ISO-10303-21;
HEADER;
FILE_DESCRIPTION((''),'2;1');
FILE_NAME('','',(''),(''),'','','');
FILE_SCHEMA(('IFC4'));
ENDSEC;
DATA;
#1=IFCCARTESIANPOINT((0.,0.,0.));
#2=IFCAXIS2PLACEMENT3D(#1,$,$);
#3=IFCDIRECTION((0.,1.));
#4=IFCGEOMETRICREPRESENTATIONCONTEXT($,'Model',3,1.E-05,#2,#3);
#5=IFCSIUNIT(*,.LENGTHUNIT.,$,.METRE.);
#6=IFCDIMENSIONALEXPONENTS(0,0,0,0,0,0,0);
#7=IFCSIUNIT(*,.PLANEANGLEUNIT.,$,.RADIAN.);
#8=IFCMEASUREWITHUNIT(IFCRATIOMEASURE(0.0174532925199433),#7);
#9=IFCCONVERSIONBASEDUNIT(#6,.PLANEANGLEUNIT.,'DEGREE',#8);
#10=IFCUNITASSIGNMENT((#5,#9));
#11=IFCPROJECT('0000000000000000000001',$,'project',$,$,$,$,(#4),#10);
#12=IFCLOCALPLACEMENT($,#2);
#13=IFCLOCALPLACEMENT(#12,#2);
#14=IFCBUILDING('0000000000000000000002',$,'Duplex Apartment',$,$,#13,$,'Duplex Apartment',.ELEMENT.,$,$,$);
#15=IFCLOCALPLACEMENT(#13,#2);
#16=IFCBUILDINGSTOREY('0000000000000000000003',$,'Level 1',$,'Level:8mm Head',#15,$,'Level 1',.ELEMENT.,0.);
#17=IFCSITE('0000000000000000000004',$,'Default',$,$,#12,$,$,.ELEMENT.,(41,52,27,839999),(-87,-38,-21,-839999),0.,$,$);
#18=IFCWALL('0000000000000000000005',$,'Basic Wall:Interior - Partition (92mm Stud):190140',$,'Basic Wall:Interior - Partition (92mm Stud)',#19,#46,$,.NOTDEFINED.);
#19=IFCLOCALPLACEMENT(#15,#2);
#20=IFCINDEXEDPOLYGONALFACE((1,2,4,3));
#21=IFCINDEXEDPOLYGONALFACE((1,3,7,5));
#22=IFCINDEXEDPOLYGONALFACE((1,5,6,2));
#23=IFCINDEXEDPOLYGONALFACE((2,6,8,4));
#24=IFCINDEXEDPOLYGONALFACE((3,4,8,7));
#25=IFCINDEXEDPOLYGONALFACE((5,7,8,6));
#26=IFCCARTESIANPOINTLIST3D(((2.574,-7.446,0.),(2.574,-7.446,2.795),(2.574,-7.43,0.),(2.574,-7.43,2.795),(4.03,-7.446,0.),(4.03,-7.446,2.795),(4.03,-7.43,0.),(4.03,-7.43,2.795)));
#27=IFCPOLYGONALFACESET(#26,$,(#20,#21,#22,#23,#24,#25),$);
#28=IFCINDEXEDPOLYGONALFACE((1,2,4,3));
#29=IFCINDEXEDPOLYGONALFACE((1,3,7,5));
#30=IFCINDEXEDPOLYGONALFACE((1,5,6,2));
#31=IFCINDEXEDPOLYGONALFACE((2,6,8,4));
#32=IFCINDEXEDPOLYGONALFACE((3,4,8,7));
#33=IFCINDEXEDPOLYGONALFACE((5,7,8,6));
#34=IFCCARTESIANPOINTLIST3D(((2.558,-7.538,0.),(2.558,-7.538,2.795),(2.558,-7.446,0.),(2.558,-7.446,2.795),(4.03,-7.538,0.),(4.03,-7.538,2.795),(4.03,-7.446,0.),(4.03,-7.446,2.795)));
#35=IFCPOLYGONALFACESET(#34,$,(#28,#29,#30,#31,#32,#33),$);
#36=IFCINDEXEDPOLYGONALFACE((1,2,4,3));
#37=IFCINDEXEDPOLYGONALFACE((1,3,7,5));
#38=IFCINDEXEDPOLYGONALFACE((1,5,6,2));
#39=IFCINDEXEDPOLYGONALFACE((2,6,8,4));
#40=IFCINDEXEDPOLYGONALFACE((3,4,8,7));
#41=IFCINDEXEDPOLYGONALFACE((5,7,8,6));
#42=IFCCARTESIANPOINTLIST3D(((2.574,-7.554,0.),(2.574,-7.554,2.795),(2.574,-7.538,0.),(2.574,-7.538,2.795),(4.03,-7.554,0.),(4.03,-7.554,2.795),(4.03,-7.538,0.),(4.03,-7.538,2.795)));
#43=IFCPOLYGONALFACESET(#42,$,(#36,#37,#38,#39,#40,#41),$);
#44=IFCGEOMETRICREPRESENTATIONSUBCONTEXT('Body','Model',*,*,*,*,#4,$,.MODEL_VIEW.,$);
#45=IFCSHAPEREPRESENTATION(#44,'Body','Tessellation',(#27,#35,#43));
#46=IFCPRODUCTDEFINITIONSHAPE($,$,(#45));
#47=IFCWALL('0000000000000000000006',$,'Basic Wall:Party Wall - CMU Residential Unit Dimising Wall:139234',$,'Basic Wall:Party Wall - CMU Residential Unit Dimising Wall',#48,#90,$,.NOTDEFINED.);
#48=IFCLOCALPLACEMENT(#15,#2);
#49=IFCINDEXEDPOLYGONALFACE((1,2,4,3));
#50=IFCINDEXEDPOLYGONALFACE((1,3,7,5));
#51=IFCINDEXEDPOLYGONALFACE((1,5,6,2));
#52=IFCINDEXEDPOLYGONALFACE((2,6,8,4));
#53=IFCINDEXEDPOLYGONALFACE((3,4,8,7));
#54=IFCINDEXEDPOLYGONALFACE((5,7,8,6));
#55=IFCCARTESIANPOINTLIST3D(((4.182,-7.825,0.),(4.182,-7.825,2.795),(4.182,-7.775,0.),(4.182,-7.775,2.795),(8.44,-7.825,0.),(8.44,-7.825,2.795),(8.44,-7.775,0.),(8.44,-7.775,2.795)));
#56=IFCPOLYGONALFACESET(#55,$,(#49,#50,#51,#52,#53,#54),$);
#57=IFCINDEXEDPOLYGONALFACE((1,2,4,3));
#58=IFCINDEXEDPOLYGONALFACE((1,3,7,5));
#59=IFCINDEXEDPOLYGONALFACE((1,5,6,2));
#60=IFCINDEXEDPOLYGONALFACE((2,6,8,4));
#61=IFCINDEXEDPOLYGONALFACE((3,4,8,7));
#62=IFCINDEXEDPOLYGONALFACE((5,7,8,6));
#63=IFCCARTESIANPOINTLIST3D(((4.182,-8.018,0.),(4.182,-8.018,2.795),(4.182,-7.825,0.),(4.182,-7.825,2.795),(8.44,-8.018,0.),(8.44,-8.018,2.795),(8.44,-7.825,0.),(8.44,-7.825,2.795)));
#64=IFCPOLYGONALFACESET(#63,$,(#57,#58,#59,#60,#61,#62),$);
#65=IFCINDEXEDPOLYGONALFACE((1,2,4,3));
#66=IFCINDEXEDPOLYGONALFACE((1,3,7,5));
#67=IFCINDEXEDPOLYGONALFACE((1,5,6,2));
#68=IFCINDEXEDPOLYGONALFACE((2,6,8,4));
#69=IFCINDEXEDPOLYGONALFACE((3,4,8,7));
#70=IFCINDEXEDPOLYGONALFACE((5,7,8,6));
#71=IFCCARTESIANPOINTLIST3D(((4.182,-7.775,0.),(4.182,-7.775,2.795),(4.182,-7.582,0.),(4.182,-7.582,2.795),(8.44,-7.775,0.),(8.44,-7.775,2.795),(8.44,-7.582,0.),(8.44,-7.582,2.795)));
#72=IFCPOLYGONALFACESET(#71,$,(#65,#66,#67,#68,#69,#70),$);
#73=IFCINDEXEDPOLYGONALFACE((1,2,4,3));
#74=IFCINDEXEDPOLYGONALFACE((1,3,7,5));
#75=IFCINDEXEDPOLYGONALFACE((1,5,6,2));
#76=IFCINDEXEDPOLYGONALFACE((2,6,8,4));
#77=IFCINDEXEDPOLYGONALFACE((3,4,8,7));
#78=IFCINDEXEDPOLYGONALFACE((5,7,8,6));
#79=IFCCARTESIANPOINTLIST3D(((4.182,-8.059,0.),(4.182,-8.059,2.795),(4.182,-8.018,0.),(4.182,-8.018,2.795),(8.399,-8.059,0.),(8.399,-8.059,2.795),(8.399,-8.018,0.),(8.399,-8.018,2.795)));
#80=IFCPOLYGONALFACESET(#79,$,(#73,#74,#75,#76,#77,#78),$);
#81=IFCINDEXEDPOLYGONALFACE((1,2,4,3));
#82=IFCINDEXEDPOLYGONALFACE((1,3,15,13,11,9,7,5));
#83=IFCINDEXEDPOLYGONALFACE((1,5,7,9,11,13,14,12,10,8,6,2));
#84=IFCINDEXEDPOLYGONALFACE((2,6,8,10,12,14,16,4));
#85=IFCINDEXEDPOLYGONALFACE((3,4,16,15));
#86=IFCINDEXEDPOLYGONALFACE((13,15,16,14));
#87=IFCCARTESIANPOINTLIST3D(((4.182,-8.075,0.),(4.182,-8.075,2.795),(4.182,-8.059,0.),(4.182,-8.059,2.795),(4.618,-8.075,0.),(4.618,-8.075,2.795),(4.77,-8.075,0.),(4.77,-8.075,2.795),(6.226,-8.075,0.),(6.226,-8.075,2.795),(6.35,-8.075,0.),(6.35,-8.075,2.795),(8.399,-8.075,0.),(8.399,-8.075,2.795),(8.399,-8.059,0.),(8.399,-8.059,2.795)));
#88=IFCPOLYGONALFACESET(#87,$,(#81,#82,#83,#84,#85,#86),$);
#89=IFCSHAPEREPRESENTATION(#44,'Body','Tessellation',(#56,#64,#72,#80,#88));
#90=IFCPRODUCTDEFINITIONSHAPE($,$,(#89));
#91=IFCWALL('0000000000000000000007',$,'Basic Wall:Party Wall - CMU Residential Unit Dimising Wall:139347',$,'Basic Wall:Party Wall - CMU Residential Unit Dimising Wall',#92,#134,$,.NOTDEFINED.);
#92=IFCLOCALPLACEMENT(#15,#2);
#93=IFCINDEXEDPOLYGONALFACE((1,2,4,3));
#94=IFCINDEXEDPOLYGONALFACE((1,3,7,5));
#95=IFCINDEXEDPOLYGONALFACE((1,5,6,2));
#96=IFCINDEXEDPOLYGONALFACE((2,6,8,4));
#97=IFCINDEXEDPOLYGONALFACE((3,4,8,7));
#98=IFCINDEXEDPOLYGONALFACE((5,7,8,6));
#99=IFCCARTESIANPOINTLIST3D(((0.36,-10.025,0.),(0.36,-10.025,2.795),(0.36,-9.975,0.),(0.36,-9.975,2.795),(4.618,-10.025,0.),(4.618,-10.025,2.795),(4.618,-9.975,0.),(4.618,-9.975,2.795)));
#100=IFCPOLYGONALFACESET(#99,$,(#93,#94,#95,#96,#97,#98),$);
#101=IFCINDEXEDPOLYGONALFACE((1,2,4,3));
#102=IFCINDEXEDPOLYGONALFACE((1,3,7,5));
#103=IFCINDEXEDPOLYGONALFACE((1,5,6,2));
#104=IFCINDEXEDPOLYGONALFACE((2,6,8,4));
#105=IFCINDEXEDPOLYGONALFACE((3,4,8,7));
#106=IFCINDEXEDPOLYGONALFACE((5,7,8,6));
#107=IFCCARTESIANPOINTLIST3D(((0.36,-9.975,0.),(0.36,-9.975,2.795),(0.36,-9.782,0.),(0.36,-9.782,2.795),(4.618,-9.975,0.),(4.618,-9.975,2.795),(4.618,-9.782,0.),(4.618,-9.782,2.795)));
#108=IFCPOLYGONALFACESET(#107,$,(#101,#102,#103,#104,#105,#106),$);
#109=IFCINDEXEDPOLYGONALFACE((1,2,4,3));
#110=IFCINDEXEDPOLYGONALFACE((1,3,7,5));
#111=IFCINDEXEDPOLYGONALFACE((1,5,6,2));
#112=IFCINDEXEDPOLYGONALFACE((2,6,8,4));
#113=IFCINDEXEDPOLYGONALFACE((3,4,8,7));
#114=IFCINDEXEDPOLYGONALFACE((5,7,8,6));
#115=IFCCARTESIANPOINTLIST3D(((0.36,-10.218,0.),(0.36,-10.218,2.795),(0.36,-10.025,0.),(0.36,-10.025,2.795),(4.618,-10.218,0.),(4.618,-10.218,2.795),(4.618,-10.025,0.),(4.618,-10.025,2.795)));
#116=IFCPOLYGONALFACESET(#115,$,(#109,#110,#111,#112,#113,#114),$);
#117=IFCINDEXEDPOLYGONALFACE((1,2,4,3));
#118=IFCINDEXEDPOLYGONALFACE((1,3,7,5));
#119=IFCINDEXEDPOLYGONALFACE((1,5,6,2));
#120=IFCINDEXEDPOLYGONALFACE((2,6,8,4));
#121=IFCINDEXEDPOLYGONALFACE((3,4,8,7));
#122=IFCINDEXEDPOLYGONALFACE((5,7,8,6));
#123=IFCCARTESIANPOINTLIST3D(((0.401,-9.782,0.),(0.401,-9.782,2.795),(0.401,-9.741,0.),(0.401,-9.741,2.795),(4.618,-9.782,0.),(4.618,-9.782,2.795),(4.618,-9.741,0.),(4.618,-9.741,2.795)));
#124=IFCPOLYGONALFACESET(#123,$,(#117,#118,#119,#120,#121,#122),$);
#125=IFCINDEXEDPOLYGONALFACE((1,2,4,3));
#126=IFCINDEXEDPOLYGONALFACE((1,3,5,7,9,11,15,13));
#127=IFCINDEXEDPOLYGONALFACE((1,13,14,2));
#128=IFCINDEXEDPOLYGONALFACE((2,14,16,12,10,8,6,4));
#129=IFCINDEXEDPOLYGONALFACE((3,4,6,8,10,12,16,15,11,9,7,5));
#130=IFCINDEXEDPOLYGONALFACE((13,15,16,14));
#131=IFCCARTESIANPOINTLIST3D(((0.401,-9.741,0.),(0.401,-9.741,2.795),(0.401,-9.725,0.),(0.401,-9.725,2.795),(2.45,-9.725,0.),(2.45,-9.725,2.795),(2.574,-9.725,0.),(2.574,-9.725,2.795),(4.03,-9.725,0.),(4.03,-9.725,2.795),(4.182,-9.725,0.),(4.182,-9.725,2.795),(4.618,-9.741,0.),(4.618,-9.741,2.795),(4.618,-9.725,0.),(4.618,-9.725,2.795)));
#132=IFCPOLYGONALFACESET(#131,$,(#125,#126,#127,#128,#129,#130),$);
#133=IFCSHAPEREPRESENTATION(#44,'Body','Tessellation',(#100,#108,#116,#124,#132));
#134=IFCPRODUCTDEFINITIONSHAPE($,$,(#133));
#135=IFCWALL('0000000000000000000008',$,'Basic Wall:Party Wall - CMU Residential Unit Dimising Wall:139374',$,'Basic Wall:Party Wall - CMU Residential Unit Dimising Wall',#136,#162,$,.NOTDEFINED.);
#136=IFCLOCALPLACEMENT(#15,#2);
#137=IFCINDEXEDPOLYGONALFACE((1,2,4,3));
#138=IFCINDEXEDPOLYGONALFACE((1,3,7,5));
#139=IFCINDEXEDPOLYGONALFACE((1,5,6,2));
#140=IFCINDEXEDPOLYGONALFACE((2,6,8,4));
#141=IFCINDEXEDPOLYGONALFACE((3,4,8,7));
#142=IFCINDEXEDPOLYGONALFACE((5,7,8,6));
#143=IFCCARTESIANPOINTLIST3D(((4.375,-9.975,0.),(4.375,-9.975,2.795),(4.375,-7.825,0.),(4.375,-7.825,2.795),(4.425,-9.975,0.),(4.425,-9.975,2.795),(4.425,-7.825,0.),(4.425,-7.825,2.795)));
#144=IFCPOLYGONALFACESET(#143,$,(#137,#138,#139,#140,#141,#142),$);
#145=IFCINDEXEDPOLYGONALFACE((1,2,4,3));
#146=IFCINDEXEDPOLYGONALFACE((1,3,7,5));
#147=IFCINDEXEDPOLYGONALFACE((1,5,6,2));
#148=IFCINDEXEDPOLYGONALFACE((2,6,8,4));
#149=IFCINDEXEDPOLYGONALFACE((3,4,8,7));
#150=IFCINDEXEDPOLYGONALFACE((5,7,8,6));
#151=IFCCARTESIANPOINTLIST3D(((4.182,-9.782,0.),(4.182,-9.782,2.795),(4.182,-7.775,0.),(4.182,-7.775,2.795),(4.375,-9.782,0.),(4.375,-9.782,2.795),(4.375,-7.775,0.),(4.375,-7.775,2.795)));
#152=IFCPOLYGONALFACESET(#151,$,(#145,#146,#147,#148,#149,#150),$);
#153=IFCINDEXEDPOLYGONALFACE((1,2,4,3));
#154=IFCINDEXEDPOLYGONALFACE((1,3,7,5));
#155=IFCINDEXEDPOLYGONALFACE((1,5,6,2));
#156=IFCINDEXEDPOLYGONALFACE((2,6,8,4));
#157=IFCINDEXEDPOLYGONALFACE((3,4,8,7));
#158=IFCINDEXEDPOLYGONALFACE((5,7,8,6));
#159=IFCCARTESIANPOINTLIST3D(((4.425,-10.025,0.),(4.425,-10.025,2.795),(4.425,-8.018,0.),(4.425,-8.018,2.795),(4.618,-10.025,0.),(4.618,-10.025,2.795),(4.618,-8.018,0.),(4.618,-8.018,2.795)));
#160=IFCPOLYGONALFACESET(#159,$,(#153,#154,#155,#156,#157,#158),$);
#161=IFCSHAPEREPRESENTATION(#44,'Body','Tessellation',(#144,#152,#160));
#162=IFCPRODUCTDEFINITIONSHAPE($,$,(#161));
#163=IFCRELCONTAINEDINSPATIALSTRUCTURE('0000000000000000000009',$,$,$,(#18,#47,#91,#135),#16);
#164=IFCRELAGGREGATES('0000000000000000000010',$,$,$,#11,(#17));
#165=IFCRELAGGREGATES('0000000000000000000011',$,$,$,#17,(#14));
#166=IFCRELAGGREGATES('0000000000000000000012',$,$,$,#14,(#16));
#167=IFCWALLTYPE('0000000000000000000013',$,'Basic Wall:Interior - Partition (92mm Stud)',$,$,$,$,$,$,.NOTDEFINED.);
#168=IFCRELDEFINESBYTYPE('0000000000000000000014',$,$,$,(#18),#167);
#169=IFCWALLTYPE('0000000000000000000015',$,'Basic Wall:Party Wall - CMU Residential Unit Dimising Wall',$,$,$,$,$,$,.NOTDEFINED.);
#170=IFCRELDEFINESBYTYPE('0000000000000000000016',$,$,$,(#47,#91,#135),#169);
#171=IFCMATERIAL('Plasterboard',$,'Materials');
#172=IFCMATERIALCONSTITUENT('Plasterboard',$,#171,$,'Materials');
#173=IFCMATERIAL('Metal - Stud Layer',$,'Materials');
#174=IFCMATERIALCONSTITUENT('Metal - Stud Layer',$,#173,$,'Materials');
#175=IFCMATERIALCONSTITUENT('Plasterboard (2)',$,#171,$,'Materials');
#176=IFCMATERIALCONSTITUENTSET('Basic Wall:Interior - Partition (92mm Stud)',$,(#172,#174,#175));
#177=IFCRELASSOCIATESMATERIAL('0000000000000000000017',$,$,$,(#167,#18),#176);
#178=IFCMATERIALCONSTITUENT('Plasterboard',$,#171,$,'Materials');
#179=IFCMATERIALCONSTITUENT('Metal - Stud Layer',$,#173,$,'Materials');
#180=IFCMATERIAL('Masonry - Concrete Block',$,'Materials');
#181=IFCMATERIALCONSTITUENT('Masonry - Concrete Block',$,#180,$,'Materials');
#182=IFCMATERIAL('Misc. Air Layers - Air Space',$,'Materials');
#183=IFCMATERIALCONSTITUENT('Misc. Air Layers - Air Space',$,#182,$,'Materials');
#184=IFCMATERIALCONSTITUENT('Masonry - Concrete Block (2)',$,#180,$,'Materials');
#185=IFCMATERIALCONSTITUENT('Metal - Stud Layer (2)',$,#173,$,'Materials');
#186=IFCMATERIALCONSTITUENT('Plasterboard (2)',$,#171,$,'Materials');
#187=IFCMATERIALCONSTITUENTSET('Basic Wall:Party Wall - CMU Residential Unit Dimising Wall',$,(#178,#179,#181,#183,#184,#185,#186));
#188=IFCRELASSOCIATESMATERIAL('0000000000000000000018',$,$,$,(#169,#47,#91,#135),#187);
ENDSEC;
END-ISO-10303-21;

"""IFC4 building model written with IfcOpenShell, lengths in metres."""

from ifc_helpers import new_model, entity, si_unit, converted_unit, direction, frame, origin, place, context, subcontext, project, spatial, indexed_curve, outline, extrude, material, constituent, constituent_set, type_object, element, save


model = new_model("IFC4")

# Units and contexts
model_context = context("Model", 3, precision=1e-05, world=origin(), true_north=direction((0.0, 1.0)))
body_context = subcontext(model_context, "Body", "Model", "MODEL_VIEW")
ifc_project = project(units=[si_unit("LENGTHUNIT", "METRE"), converted_unit("PLANEANGLEUNIT", "DEGREE", entity("IfcRatioMeasure", 0.0174532925199433), si_unit("PLANEANGLEUNIT", "RADIAN"), dimensions=[0, 0, 0, 0, 0, 0, 0])], contexts=[model_context])

# Site, building, storey
site_placement = place(None, origin())
site = spatial("IfcSite", under=ifc_project, at=site_placement, Name="Default", CompositionType="ELEMENT", RefLatitude=(41, 52, 27, 839999), RefLongitude=(-87, -38, -21, -839999), RefElevation=0.0)
building_placement = place(site_placement, origin())
building = spatial("IfcBuilding", under=site, at=building_placement, Name="Duplex Apartment", LongName="Duplex Apartment", CompositionType="ELEMENT")
storey_placement = place(building_placement, origin())
storey = spatial("IfcBuildingStorey", under=building, at=storey_placement, Name="Level 1", ObjectType="Level:8mm Head", LongName="Level 1", CompositionType="ELEMENT", Elevation=0.0)

# Shared definitions
ifc_material_1 = material(Name="Plasterboard", Category="Materials")
ifc_constituent_1 = constituent(ifc_material_1, Name="Plasterboard", Category="Materials")
ifc_material_2 = material(Name="Metal - Stud Layer", Category="Materials")
ifc_constituent_2 = constituent(ifc_material_2, Name="Metal - Stud Layer", Category="Materials")
ifc_constituent_3 = constituent(ifc_material_1, Name="Plasterboard (2)", Category="Materials")
ifc_constituent_set_1 = constituent_set(constituents=[ifc_constituent_1, ifc_constituent_2, ifc_constituent_3], Name="Basic Wall:Interior - Partition (92mm Stud)")
wall_type_1 = type_object("IfcWallType", Name="Basic Wall:Interior - Partition (92mm Stud)", PredefinedType="NOTDEFINED", material=ifc_constituent_set_1)

# Walls
wall_1_placement = place(storey_placement, frame((4.03, -7.492, 0.0), z_axis=(0.0, 0.0, 1.0), x_axis=(-1.0, 0.0, 0.0)))
element("IfcWall", 1, at=wall_1_placement, inside=storey, type_object=wall_type_1, material=ifc_constituent_set_1, Name="Basic Wall:Interior - Partition (92mm Stud):190140", ObjectType="Basic Wall:Interior - Partition (92mm Stud)", PredefinedType="NOTDEFINED", context=body_context, shape_type="SweptSolid", body=[
    extrude(outline(indexed_curve([(-0.008, -0.728), (0.008, -0.728), (0.008, 0.728), (-0.008, 0.728), (-0.008, -0.728)], self_intersect=False)), frame((0.728, -0.054, 0.0), z_axis=(0.0, 0.0, 1.0), x_axis=(0.0, 1.0, 0.0)), (0.0, 0.0, 1.0), 2.795),
    extrude(outline(indexed_curve([(-0.736, -0.046), (0.736, -0.046), (0.736, 0.046), (-0.736, 0.046), (-0.736, -0.046)], self_intersect=False)), frame((0.736, 0.0, 0.0)), (0.0, 0.0, 1.0), 2.795),
    extrude(outline(indexed_curve([(-0.008, -0.728), (0.008, -0.728), (0.008, 0.728), (-0.008, 0.728), (-0.008, -0.728)], self_intersect=False)), frame((0.728, 0.054, 0.0), z_axis=(0.0, 0.0, 1.0), x_axis=(0.0, -1.0, 0.0)), (0.0, 0.0, 1.0), 2.795),
])
ifc_constituent_4 = constituent(ifc_material_1, Name="Plasterboard", Category="Materials")
ifc_constituent_5 = constituent(ifc_material_2, Name="Metal - Stud Layer", Category="Materials")
ifc_material_3 = material(Name="Masonry - Concrete Block", Category="Materials")
ifc_constituent_6 = constituent(ifc_material_3, Name="Masonry - Concrete Block", Category="Materials")
ifc_material_4 = material(Name="Misc. Air Layers - Air Space", Category="Materials")
ifc_constituent_7 = constituent(ifc_material_4, Name="Misc. Air Layers - Air Space", Category="Materials")
ifc_constituent_8 = constituent(ifc_material_3, Name="Masonry - Concrete Block (2)", Category="Materials")
ifc_constituent_9 = constituent(ifc_material_2, Name="Metal - Stud Layer (2)", Category="Materials")
ifc_constituent_10 = constituent(ifc_material_1, Name="Plasterboard (2)", Category="Materials")
ifc_constituent_set_2 = constituent_set(constituents=[ifc_constituent_4, ifc_constituent_5, ifc_constituent_6, ifc_constituent_7, ifc_constituent_8, ifc_constituent_9, ifc_constituent_10], Name="Basic Wall:Party Wall - CMU Residential Unit Dimising Wall")
wall_type_2 = type_object("IfcWallType", Name="Basic Wall:Party Wall - CMU Residential Unit Dimising Wall", PredefinedType="NOTDEFINED", material=ifc_constituent_set_2)
wall_2_placement = place(storey_placement, frame((8.383, -7.8, 0.0), z_axis=(0.0, 0.0, 1.0), x_axis=(-1.0, 0.0, 0.0)))
element("IfcWall", 2, at=wall_2_placement, inside=storey, type_object=wall_type_2, material=ifc_constituent_set_2, Name="Basic Wall:Party Wall - CMU Residential Unit Dimising Wall:139234", ObjectType="Basic Wall:Party Wall - CMU Residential Unit Dimising Wall", PredefinedType="NOTDEFINED", context=body_context, shape_type="SweptSolid", body=[
    extrude(outline(indexed_curve([(-2.129, -0.025), (2.129, -0.025), (2.129, 0.025), (-2.129, 0.025), (-2.129, -0.025)], self_intersect=False)), frame((2.072, 0.0, 0.0)), (0.0, 0.0, 1.0), 2.795),
    extrude(outline(indexed_curve([(-2.129, -0.0965), (2.129, -0.0965), (2.129, 0.0965), (-2.129, 0.0965), (-2.129, -0.0965)], self_intersect=False)), frame((2.072, 0.1215, 0.0)), (0.0, 0.0, 1.0), 2.795),
    extrude(outline(indexed_curve([(-2.129, -0.0965), (2.129, -0.0965), (2.129, 0.0965), (-2.129, 0.0965), (-2.129, -0.0965)], self_intersect=False)), frame((2.072, -0.1215, 0.0)), (0.0, 0.0, 1.0), 2.795),
    extrude(outline(indexed_curve([(-2.1085, -0.0205), (2.1085, -0.0205), (2.1085, 0.0205), (-2.1085, 0.0205), (-2.1085, -0.0205)], self_intersect=False)), frame((2.0925, 0.2385, 0.0)), (0.0, 0.0, 1.0), 2.795),
    extrude(outline(indexed_curve([(-1.2728, -0.004), (-1.1207, -0.004), (0.3353, -0.004), (0.4593, -0.004), (2.5082, -0.004), (2.5082, 0.012), (-1.7087, 0.012), (-1.7087, -0.004), (-1.2728, -0.004)], self_intersect=False)), frame((2.4922, 0.271, 0.0), z_axis=(0.0, 0.0, 1.0), x_axis=(-1.0, 0.0, 0.0)), (0.0, 0.0, 1.0), 2.795),
])
wall_3_placement = place(storey_placement, frame((0.417, -10.0, 0.0)))
element("IfcWall", 3, at=wall_3_placement, inside=storey, type_object=wall_type_2, material=ifc_constituent_set_2, Name="Basic Wall:Party Wall - CMU Residential Unit Dimising Wall:139347", ObjectType="Basic Wall:Party Wall - CMU Residential Unit Dimising Wall", PredefinedType="NOTDEFINED", context=body_context, shape_type="SweptSolid", body=[
    extrude(outline(indexed_curve([(-2.129, -0.025), (2.129, -0.025), (2.129, 0.025), (-2.129, 0.025), (-2.129, -0.025)], self_intersect=False)), frame((2.072, 0.0, 0.0)), (0.0, 0.0, 1.0), 2.795),
    extrude(outline(indexed_curve([(-2.129, -0.0965), (2.129, -0.0965), (2.129, 0.0965), (-2.129, 0.0965), (-2.129, -0.0965)], self_intersect=False)), frame((2.072, 0.1215, 0.0)), (0.0, 0.0, 1.0), 2.795),
    extrude(outline(indexed_curve([(-2.129, -0.0965), (2.129, -0.0965), (2.129, 0.0965), (-2.129, 0.0965), (-2.129, -0.0965)], self_intersect=False)), frame((2.072, -0.1215, 0.0)), (0.0, 0.0, 1.0), 2.795),
    extrude(outline(indexed_curve([(-2.1085, -0.0205), (2.1085, -0.0205), (2.1085, 0.0205), (-2.1085, 0.0205), (-2.1085, -0.0205)], self_intersect=False)), frame((2.0925, 0.2385, 0.0)), (0.0, 0.0, 1.0), 2.795),
    extrude(outline(indexed_curve([(-1.2728, -0.004), (-1.1207, -0.004), (0.3353, -0.004), (0.4593, -0.004), (2.5082, -0.004), (2.5082, 0.012), (-1.7087, 0.012), (-1.7087, -0.004), (-1.2728, -0.004)], self_intersect=False)), frame((2.4922, 0.271, 0.0), z_axis=(0.0, 0.0, 1.0), x_axis=(-1.0, 0.0, 0.0)), (0.0, 0.0, 1.0), 2.795),
])
wall_4_placement = place(storey_placement, frame((4.4, -10.0, 0.0), z_axis=(0.0, 0.0, 1.0), x_axis=(0.0, 1.0, 0.0)))
element("IfcWall", 4, at=wall_4_placement, inside=storey, type_object=wall_type_2, material=ifc_constituent_set_2, Name="Basic Wall:Party Wall - CMU Residential Unit Dimising Wall:139374", ObjectType="Basic Wall:Party Wall - CMU Residential Unit Dimising Wall", PredefinedType="NOTDEFINED", context=body_context, shape_type="SweptSolid", body=[
    extrude(outline(indexed_curve([(-1.075, -0.025), (1.075, -0.025), (1.075, 0.025), (-1.075, 0.025), (-1.075, -0.025)], self_intersect=False)), frame((1.1, 0.0, 0.0), z_axis=(0.0, 0.0, 1.0), x_axis=(-1.0, 0.0, 0.0)), (0.0, 0.0, 1.0), 2.795),
    extrude(outline(indexed_curve([(-1.0035, -0.0965), (1.0035, -0.0965), (1.0035, 0.0965), (-1.0035, 0.0965), (-1.0035, -0.0965)], self_intersect=False)), frame((1.2215, 0.1215, 0.0), z_axis=(0.0, 0.0, 1.0), x_axis=(-1.0, 0.0, 0.0)), (0.0, 0.0, 1.0), 2.795),
    extrude(outline(indexed_curve([(-1.0035, -0.0965), (1.0035, -0.0965), (1.0035, 0.0965), (-1.0035, 0.0965), (-1.0035, -0.0965)], self_intersect=False)), frame((0.9785, -0.1215, 0.0), z_axis=(0.0, 0.0, 1.0), x_axis=(-1.0, 0.0, 0.0)), (0.0, 0.0, 1.0), 2.795),
])

save(model, "model.ifc")
